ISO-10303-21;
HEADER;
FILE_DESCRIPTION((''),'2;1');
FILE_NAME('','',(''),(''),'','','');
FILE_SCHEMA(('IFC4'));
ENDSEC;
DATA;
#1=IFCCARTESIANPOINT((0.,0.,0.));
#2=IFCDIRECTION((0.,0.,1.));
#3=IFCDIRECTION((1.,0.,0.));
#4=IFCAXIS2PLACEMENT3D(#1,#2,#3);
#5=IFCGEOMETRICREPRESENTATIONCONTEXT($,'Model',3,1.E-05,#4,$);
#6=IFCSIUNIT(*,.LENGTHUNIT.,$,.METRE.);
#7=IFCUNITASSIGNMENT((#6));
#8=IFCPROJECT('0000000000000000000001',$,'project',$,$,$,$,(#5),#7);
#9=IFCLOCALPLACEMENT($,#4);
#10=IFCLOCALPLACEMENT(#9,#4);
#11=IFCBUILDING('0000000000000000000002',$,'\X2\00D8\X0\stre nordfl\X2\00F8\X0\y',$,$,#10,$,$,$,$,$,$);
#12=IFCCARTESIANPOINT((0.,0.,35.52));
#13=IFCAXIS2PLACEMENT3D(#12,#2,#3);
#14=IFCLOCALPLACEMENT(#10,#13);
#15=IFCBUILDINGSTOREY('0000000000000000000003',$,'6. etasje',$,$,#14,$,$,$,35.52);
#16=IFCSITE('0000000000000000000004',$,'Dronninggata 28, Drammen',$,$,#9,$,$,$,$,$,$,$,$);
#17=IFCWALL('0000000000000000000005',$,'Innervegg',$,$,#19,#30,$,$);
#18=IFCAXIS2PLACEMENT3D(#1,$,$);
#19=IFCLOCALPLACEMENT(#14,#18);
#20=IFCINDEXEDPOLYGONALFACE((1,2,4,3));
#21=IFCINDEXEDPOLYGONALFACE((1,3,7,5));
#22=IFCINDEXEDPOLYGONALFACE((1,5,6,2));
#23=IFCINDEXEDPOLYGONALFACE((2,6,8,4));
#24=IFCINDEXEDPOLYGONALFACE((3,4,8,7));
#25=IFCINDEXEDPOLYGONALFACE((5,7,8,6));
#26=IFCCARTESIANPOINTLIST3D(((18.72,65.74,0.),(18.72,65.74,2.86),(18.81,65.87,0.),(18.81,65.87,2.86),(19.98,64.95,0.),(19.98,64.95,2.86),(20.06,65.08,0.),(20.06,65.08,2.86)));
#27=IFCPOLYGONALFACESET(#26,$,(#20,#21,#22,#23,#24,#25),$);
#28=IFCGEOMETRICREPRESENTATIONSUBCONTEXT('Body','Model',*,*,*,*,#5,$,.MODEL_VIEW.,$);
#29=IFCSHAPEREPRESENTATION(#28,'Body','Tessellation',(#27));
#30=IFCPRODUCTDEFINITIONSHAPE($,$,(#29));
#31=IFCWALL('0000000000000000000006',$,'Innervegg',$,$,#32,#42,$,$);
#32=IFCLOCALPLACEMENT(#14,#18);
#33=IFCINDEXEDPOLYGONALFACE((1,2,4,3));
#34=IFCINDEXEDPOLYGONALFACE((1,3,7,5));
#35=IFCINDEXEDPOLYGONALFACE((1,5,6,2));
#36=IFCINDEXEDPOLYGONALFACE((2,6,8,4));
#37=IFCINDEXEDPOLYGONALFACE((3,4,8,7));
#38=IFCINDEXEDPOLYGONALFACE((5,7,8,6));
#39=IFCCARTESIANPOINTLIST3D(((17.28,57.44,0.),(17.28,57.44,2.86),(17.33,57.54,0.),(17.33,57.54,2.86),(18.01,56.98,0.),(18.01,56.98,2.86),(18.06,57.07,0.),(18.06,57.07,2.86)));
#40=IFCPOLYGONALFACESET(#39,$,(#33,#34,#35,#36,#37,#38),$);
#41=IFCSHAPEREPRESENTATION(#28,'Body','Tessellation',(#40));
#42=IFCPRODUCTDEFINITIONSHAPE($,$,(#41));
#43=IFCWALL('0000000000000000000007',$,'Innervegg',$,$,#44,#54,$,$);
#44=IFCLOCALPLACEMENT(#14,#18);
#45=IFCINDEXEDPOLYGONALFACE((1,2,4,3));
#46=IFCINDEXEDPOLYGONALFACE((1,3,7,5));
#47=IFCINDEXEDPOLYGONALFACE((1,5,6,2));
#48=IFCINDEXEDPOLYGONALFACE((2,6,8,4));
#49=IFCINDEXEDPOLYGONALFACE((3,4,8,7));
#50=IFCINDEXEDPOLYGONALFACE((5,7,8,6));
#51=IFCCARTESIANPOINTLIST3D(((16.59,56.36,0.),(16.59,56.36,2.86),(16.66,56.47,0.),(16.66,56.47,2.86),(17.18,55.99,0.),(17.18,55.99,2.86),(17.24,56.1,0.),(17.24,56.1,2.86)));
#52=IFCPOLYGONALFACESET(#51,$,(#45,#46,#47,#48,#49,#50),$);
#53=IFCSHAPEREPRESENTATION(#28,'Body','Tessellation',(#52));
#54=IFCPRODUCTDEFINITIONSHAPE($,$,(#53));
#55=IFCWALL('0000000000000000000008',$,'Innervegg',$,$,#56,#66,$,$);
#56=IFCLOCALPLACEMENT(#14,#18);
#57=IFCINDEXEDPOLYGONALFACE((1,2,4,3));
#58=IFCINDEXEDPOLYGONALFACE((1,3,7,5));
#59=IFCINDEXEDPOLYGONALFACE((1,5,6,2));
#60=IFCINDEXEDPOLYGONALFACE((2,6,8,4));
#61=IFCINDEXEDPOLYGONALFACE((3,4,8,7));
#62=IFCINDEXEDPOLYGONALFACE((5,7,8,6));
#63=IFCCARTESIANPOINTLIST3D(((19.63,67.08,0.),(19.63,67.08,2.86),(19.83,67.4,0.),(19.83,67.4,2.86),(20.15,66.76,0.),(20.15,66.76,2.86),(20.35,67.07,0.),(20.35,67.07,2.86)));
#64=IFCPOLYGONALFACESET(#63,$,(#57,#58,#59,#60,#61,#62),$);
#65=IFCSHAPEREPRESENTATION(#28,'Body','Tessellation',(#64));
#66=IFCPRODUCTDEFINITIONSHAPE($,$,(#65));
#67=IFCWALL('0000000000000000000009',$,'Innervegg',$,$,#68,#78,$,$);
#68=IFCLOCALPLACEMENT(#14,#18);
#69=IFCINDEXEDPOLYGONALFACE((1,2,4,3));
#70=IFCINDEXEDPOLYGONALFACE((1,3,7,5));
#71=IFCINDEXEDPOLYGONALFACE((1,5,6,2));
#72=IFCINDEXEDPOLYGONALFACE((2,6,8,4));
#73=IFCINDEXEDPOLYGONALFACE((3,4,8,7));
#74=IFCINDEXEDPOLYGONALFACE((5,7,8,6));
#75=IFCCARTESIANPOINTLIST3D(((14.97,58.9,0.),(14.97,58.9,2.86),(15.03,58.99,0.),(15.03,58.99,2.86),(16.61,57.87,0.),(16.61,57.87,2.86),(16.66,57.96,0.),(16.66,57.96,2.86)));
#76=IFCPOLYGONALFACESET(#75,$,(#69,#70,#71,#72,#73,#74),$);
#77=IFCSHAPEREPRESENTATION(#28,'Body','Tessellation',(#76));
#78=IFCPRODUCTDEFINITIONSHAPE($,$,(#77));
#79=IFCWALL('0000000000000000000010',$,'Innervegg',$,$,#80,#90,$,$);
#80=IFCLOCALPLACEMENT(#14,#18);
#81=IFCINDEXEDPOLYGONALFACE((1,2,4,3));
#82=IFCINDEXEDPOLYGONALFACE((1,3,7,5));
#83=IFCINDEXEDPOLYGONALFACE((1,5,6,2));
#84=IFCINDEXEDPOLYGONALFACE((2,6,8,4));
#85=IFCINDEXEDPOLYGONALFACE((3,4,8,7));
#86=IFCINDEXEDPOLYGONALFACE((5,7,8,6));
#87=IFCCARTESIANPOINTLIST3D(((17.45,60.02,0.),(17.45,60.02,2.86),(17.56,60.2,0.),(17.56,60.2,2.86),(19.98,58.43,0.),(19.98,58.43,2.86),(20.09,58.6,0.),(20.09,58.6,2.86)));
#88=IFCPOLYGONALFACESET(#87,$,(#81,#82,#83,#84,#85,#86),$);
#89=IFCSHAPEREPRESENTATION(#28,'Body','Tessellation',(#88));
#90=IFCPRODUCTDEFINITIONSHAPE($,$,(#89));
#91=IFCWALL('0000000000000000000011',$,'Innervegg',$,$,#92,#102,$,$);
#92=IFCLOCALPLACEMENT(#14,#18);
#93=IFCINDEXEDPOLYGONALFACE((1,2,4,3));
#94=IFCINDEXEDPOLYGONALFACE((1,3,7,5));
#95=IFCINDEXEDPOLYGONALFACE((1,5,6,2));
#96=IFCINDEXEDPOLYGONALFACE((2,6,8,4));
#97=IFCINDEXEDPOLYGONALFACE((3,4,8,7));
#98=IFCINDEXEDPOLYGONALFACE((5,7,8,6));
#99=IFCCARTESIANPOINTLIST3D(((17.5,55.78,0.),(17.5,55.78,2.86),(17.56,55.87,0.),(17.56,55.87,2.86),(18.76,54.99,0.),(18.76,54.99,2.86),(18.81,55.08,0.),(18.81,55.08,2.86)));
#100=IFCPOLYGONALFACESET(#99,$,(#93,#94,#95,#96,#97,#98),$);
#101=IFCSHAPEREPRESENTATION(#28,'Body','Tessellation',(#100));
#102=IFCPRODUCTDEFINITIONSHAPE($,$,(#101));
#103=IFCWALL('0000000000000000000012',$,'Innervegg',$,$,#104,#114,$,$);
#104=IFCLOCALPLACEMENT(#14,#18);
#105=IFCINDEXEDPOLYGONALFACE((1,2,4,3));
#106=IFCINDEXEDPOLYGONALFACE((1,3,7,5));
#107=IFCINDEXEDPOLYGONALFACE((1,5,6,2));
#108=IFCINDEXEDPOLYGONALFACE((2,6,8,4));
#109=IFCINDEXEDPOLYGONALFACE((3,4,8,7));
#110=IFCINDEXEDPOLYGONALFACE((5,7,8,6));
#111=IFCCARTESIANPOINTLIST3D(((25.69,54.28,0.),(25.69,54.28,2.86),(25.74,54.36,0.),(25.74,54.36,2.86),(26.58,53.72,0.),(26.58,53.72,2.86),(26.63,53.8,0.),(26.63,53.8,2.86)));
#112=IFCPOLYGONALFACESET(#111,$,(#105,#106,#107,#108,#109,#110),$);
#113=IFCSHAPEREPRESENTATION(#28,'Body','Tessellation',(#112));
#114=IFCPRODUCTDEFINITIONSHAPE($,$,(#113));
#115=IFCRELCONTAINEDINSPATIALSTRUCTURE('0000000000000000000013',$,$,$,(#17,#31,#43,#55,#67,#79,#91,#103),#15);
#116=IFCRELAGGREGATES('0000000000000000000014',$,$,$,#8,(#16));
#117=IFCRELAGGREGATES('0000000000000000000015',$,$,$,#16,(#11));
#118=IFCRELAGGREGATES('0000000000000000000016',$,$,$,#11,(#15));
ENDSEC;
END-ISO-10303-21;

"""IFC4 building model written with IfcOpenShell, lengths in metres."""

from ifc_helpers import new_model, si_unit, frame, origin_with_axes, place, context, subcontext, project, spatial, polyline, outline, extrude, element, save


model = new_model("IFC4")

# Units and contexts
model_context = context("Model", 3, precision=1e-05, world=origin_with_axes())
body_context = subcontext(model_context, "Body", "Model", "MODEL_VIEW")
ifc_project = project(units=[si_unit("LENGTHUNIT", "METRE")], contexts=[model_context])

# Site, building, storey
site_placement = place(None, origin_with_axes())
site = spatial("IfcSite", under=ifc_project, at=site_placement, Name="Dronninggata 28, Drammen")
building_placement = place(site_placement, origin_with_axes())
building = spatial("IfcBuilding", under=site, at=building_placement, Name="Østre nordfløy")
storey_placement = place(building_placement, frame((0.0, 0.0, 35.52), z_axis=(0.0, 0.0, 1.0), x_axis=(1.0, 0.0, 0.0)))
storey = spatial("IfcBuildingStorey", under=building, at=storey_placement, Name="6. etasje", Elevation=35.52)

# Walls
wall_1_placement = place(storey_placement, frame((0.0, 0.0, -35.52), z_axis=(0.0, 0.0, 1.0), x_axis=(1.0, 0.0, 0.0)))
element("IfcWall", 1, at=wall_1_placement, inside=storey, Name="Innervegg", context=body_context, shape_type="SweptSolid", body=[
    extrude(outline(polyline([(20.06, 65.08), (19.98, 64.95), (18.72, 65.74), (18.81, 65.87), (20.06, 65.08)])), frame((0.0, 0.0, 35.52)), (0.0, 0.0, 1.0), 2.86),
])
wall_2_placement = place(storey_placement, frame((0.0, 0.0, -35.52), z_axis=(0.0, 0.0, 1.0), x_axis=(1.0, 0.0, 0.0)))
element("IfcWall", 2, at=wall_2_placement, inside=storey, Name="Innervegg", context=body_context, shape_type="SweptSolid", body=[
    extrude(outline(polyline([(18.06, 57.07), (18.01, 56.98), (17.28, 57.44), (17.33, 57.54), (18.06, 57.07)])), frame((0.0, 0.0, 35.52)), (0.0, 0.0, 1.0), 2.86),
])
wall_3_placement = place(storey_placement, frame((0.0, 0.0, -35.52), z_axis=(0.0, 0.0, 1.0), x_axis=(1.0, 0.0, 0.0)))
element("IfcWall", 3, at=wall_3_placement, inside=storey, Name="Innervegg", context=body_context, shape_type="SweptSolid", body=[
    extrude(outline(polyline([(17.24, 56.1), (17.18, 55.99), (16.59, 56.36), (16.66, 56.47), (17.24, 56.1)])), frame((0.0, 0.0, 35.52)), (0.0, 0.0, 1.0), 2.86),
])
wall_4_placement = place(storey_placement, frame((0.0, 0.0, -35.52), z_axis=(0.0, 0.0, 1.0), x_axis=(1.0, 0.0, 0.0)))
element("IfcWall", 4, at=wall_4_placement, inside=storey, Name="Innervegg", context=body_context, shape_type="SweptSolid", body=[
    extrude(outline(polyline([(20.35, 67.07), (20.15, 66.76), (19.63, 67.08), (19.83, 67.4), (20.35, 67.07)])), frame((0.0, 0.0, 35.52)), (0.0, 0.0, 1.0), 2.86),
])
wall_5_placement = place(storey_placement, frame((0.0, 0.0, -35.52), z_axis=(0.0, 0.0, 1.0), x_axis=(1.0, 0.0, 0.0)))
element("IfcWall", 5, at=wall_5_placement, inside=storey, Name="Innervegg", context=body_context, shape_type="SweptSolid", body=[
    extrude(outline(polyline([(16.66, 57.96), (16.61, 57.87), (14.97, 58.9), (15.03, 58.99), (16.66, 57.96)])), frame((0.0, 0.0, 35.52)), (0.0, 0.0, 1.0), 2.86),
])
wall_6_placement = place(storey_placement, frame((0.0, 0.0, -35.52), z_axis=(0.0, 0.0, 1.0), x_axis=(1.0, 0.0, 0.0)))
element("IfcWall", 6, at=wall_6_placement, inside=storey, Name="Innervegg", context=body_context, shape_type="SweptSolid", body=[
    extrude(outline(polyline([(20.09, 58.6), (19.98, 58.43), (17.45, 60.02), (17.56, 60.2), (20.09, 58.6)])), frame((0.0, 0.0, 35.52)), (0.0, 0.0, 1.0), 2.86),
])
wall_7_placement = place(storey_placement, frame((0.0, 0.0, -35.52), z_axis=(0.0, 0.0, 1.0), x_axis=(1.0, 0.0, 0.0)))
element("IfcWall", 7, at=wall_7_placement, inside=storey, Name="Innervegg", context=body_context, shape_type="SweptSolid", body=[
    extrude(outline(polyline([(18.81, 55.08), (18.76, 54.99), (17.5, 55.78), (17.56, 55.87), (18.81, 55.08)])), frame((0.0, 0.0, 35.52)), (0.0, 0.0, 1.0), 2.86),
])
wall_8_placement = place(storey_placement, frame((0.0, 0.0, -35.52), z_axis=(0.0, 0.0, 1.0), x_axis=(1.0, 0.0, 0.0)))
element("IfcWall", 8, at=wall_8_placement, inside=storey, Name="Innervegg", context=body_context, shape_type="SweptSolid", body=[
    extrude(outline(polyline([(26.63, 53.8), (26.58, 53.72), (25.69, 54.28), (25.74, 54.36), (26.63, 53.8)])), frame((0.0, 0.0, 35.52)), (0.0, 0.0, 1.0), 2.86),
])

save(model, "model.ifc")
